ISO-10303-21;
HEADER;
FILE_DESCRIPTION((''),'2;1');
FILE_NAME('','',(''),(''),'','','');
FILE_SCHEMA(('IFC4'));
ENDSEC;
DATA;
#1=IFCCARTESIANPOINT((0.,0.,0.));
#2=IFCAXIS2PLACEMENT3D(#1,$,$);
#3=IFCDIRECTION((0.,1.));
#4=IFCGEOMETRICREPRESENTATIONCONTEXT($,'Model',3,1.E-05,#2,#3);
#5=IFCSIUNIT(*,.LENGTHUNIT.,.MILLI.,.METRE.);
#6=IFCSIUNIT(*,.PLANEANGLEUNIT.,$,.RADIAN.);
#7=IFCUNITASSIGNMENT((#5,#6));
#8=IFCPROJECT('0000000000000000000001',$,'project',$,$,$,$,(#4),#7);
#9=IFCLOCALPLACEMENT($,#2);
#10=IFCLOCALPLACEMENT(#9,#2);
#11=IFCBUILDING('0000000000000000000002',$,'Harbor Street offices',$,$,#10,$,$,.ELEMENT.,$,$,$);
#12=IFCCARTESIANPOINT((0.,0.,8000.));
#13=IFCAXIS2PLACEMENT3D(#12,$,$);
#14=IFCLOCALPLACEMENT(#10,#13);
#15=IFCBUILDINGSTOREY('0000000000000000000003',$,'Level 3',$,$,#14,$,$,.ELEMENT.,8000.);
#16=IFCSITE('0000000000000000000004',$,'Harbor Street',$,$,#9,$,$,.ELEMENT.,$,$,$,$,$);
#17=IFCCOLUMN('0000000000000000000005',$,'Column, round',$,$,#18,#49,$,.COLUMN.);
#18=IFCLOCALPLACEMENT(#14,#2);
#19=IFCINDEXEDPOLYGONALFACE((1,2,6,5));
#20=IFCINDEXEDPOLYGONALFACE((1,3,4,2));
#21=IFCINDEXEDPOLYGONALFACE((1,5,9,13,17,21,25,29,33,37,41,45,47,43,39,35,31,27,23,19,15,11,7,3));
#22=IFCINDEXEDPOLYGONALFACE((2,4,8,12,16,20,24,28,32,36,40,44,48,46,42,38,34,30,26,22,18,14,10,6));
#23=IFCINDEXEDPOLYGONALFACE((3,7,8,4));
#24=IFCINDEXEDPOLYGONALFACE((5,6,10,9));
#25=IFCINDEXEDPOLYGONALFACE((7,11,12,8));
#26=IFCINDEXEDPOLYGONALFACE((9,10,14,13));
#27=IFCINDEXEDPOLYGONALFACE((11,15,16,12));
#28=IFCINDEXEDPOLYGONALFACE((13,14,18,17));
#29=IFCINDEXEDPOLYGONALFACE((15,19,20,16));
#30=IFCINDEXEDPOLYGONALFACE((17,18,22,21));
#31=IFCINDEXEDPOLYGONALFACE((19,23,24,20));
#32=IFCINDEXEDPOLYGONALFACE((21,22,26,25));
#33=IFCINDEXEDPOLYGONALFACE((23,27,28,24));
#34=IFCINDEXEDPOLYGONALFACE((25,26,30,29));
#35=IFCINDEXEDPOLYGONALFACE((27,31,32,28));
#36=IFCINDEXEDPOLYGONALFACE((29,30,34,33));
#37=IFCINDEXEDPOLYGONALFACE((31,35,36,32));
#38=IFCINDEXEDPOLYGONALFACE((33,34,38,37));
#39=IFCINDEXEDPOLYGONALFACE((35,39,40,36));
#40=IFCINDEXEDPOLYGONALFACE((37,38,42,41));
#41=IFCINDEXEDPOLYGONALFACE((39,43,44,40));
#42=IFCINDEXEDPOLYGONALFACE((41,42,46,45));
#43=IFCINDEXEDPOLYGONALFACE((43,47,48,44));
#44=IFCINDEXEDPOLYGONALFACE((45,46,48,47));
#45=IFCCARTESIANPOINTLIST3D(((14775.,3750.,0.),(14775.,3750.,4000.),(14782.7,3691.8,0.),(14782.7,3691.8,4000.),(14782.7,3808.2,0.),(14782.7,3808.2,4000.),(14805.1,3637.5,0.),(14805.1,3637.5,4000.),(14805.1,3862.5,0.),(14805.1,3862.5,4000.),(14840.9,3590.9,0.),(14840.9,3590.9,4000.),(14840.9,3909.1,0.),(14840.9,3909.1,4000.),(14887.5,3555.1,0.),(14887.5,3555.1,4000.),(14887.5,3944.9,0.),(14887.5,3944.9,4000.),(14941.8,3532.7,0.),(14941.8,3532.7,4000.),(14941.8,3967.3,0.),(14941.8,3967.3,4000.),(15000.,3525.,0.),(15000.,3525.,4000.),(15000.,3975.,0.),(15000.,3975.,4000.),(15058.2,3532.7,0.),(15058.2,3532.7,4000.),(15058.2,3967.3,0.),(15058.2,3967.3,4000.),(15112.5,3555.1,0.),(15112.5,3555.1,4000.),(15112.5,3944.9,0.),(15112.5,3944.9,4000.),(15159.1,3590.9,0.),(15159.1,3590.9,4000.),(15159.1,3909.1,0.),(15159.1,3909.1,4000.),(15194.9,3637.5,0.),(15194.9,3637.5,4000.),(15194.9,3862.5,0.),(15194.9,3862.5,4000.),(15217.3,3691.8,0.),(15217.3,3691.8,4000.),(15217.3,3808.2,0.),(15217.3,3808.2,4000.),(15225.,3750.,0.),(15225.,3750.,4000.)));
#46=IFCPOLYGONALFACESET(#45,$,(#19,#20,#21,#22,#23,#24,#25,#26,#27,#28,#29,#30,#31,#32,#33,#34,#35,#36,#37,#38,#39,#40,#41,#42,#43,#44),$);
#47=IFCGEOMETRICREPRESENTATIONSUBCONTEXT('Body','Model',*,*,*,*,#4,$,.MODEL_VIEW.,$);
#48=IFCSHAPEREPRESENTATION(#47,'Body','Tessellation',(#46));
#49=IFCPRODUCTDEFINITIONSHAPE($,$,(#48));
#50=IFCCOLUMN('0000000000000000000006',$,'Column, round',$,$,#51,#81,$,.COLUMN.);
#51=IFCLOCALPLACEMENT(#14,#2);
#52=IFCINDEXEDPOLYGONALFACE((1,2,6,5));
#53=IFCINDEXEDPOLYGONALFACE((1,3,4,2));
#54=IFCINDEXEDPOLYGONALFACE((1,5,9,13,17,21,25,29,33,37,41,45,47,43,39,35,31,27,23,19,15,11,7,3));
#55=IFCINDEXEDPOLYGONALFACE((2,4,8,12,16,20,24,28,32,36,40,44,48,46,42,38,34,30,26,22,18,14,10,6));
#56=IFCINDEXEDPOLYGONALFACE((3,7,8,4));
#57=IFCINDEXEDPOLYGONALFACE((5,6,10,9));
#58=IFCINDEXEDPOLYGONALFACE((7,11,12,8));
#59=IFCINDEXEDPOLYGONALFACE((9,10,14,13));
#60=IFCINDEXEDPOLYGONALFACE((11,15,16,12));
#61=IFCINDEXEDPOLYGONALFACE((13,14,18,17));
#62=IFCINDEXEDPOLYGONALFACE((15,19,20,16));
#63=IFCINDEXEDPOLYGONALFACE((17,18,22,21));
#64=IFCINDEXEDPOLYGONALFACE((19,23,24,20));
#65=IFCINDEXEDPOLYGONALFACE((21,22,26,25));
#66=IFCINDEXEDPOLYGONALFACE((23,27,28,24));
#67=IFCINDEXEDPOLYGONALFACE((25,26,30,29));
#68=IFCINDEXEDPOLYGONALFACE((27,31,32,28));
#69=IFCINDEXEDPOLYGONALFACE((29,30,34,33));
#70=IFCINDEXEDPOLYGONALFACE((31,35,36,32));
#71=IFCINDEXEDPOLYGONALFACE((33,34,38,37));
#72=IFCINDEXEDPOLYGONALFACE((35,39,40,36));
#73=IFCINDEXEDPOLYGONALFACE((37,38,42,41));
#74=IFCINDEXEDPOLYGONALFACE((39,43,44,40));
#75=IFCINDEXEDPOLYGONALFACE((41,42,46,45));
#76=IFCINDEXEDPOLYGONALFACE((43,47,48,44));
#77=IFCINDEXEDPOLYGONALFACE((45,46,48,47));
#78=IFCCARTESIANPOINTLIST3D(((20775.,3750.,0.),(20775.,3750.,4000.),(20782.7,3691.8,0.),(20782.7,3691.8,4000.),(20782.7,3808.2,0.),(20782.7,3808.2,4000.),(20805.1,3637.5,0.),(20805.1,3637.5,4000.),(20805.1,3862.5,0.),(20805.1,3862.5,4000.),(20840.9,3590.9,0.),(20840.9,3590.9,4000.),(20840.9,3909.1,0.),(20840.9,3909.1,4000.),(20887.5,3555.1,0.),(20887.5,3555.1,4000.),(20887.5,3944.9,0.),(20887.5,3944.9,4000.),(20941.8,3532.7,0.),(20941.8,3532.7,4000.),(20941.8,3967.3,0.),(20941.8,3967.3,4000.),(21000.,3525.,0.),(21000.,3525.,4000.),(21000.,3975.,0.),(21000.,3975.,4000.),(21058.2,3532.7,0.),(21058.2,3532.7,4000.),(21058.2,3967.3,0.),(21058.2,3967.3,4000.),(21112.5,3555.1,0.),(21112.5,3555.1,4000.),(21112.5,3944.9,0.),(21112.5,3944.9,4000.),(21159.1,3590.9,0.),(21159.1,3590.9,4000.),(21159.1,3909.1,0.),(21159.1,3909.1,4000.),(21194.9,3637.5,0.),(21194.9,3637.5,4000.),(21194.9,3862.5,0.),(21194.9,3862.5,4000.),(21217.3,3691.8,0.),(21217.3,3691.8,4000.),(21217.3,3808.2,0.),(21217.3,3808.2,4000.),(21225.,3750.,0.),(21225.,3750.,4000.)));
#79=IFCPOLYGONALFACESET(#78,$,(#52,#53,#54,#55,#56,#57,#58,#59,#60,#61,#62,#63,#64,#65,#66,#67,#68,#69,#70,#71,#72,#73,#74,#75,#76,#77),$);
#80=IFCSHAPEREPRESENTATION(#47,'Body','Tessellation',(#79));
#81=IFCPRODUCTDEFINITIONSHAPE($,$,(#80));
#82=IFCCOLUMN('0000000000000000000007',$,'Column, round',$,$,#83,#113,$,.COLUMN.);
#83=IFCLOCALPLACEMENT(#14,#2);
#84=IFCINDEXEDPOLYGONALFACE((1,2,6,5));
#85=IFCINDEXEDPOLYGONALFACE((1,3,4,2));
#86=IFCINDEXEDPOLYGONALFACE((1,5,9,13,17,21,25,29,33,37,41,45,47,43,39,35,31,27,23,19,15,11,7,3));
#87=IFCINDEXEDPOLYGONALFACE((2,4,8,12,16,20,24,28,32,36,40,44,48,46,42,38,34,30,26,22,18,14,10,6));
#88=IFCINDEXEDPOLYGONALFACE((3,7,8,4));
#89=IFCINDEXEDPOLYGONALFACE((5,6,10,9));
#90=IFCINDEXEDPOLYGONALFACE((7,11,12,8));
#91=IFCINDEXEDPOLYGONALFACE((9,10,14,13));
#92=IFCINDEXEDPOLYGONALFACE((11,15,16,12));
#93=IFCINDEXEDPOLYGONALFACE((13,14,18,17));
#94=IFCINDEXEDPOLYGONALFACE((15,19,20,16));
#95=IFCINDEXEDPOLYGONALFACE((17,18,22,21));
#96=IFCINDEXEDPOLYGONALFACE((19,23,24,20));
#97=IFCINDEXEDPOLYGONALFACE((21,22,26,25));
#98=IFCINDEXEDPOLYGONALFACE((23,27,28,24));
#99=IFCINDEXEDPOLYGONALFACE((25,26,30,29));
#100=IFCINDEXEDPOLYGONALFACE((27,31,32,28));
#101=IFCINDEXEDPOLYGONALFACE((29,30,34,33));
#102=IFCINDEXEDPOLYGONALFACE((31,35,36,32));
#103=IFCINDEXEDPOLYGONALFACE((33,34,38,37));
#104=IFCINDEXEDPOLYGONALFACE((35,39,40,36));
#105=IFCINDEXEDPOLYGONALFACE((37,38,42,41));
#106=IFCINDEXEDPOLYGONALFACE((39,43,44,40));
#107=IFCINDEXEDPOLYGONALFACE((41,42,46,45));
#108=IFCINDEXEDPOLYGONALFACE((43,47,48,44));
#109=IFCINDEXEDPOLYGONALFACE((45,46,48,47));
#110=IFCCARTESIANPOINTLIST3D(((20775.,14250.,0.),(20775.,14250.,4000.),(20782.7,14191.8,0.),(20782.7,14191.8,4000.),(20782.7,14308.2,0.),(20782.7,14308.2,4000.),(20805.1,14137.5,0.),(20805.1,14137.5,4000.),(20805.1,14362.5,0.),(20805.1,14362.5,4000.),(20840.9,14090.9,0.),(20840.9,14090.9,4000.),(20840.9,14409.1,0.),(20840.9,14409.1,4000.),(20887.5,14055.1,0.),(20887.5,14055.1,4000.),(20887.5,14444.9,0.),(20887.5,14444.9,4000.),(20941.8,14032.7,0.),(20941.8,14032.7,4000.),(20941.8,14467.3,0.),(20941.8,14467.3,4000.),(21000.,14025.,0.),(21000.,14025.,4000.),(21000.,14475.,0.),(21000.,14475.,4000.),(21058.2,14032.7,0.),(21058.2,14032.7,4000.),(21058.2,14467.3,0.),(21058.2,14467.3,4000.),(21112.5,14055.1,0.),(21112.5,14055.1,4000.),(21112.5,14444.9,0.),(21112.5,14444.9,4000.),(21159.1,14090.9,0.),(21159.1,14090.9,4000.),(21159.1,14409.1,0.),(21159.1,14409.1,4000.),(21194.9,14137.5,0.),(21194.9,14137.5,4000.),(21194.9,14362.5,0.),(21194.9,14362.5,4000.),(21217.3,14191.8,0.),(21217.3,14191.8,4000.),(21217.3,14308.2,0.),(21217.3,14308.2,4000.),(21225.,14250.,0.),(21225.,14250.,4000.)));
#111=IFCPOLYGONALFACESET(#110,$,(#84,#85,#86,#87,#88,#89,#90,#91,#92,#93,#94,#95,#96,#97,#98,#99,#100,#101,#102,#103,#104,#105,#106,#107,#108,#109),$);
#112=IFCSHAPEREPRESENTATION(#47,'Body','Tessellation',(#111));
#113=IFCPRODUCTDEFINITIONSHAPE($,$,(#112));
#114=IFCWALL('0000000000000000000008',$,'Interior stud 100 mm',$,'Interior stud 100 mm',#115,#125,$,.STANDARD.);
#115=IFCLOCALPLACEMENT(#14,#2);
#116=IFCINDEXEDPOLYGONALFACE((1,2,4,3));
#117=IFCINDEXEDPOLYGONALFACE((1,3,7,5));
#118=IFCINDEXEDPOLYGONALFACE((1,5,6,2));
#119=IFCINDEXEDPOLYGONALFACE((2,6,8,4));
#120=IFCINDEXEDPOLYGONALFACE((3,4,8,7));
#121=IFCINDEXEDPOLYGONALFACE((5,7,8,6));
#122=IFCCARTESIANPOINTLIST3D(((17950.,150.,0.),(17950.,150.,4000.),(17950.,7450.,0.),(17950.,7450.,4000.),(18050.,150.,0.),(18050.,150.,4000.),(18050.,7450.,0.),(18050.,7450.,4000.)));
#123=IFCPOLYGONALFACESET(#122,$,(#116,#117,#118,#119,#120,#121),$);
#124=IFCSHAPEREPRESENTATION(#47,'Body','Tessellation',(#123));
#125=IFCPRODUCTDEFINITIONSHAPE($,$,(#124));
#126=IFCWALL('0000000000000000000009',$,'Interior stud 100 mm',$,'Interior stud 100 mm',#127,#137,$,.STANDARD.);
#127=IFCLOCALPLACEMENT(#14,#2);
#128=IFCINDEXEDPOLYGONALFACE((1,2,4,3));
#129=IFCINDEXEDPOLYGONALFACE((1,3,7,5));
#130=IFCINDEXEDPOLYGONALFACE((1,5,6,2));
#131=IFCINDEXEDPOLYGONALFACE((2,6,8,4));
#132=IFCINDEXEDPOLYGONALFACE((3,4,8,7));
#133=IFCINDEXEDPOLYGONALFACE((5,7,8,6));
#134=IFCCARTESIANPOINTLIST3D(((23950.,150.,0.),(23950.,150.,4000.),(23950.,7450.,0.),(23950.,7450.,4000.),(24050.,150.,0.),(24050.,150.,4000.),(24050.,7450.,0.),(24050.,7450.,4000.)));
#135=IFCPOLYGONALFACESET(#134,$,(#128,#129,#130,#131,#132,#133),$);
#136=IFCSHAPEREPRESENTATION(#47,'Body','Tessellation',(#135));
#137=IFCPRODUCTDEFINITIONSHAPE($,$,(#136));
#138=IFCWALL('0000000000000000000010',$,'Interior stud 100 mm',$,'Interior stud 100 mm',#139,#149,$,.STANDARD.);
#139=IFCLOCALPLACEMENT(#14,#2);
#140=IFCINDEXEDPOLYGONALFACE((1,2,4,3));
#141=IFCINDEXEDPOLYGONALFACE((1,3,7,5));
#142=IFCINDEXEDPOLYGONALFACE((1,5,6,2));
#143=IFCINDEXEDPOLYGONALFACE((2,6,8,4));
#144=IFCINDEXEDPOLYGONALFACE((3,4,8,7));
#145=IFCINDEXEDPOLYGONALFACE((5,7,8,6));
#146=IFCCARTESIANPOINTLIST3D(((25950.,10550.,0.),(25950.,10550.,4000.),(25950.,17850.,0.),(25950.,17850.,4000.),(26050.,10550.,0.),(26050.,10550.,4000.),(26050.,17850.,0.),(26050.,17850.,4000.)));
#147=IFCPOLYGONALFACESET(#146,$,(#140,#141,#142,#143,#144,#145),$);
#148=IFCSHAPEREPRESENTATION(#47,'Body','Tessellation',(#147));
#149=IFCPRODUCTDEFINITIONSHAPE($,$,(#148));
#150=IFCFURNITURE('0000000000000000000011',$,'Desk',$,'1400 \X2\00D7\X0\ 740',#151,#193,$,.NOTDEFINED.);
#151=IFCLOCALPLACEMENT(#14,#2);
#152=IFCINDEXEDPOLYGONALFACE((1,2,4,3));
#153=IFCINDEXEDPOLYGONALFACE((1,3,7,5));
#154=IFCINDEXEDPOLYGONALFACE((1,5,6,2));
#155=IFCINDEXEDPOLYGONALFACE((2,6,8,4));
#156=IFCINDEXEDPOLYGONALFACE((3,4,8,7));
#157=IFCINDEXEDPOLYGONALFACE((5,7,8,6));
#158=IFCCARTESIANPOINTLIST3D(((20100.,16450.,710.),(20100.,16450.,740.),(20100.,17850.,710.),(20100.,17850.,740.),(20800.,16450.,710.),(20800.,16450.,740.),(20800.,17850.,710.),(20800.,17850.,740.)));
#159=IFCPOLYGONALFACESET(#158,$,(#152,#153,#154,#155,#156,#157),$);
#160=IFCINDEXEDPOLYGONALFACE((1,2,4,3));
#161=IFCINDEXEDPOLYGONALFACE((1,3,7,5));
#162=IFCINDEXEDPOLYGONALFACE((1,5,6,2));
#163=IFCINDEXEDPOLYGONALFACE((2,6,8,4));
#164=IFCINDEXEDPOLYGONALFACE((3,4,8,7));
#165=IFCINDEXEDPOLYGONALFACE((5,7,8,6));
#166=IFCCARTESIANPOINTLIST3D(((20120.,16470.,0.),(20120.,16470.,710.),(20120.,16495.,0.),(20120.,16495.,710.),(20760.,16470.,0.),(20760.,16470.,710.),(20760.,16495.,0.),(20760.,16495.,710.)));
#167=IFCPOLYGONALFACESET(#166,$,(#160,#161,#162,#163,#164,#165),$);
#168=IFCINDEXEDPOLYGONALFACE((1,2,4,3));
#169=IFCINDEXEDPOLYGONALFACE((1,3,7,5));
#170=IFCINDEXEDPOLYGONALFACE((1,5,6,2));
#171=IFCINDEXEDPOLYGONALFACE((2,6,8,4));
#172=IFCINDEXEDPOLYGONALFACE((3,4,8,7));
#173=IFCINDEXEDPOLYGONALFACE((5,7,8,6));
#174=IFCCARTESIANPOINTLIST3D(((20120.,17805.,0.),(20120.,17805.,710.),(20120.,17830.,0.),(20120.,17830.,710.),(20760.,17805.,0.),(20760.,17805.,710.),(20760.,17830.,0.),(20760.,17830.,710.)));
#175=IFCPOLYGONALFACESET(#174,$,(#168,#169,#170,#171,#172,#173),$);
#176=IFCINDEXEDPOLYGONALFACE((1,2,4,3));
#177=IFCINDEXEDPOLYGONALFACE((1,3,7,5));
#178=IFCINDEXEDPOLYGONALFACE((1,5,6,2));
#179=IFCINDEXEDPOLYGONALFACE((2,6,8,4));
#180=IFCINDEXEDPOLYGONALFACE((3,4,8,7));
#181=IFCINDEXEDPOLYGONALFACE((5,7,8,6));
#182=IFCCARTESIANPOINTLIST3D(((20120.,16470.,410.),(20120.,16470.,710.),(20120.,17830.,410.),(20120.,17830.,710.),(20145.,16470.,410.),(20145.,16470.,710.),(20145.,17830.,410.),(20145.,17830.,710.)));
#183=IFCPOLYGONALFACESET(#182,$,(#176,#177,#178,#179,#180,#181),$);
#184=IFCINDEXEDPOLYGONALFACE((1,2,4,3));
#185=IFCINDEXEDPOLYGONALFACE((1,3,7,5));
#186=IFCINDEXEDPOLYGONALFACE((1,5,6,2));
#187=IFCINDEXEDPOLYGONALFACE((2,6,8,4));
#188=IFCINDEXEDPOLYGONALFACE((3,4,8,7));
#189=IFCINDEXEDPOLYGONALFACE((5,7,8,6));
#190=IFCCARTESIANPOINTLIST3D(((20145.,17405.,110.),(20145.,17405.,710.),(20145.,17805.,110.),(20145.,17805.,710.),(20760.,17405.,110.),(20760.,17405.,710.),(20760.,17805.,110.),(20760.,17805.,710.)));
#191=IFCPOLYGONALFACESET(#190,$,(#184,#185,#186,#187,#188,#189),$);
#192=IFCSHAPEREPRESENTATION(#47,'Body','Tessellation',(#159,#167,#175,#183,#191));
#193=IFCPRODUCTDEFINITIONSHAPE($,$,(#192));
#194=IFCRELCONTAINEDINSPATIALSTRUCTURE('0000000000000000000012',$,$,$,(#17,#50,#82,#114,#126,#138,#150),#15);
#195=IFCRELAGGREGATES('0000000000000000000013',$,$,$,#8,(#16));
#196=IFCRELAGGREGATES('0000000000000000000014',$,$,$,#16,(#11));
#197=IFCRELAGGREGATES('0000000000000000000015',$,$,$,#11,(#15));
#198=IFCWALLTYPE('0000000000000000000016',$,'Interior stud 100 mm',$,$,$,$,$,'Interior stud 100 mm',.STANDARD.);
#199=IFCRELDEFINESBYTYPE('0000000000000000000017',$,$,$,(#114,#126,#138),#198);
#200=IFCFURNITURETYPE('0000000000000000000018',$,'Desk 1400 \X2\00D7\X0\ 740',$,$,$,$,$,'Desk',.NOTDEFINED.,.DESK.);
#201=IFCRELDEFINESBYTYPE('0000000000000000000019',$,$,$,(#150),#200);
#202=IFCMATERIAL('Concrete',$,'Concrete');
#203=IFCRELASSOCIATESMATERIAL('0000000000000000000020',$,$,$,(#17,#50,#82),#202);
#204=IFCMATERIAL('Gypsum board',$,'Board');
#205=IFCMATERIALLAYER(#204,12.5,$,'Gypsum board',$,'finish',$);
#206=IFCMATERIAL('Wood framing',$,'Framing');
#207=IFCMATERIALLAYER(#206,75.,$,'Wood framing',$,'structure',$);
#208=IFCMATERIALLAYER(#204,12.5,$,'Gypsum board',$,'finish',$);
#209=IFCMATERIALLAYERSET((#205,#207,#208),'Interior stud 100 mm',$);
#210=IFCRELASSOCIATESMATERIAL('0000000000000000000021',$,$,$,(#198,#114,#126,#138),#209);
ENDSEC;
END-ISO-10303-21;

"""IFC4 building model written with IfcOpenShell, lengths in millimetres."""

from ifc_helpers import new_model, si_unit, direction, frame, origin, origin_2d, place, context, subcontext, project, spatial, polyline, circle, outline, extrude, source, transform, mapped, material, layer, layer_set, layer_usage, type_object, type_shapes, element, save


model = new_model("IFC4")

# Units and contexts
model_context = context("Model", 3, precision=1e-05, world=origin(), true_north=direction((0.0, 1.0)))
body_context = subcontext(model_context, "Body", "Model", "MODEL_VIEW")
ifc_project = project(units=[si_unit("LENGTHUNIT", "METRE", prefix="MILLI"), si_unit("PLANEANGLEUNIT", "RADIAN")], contexts=[model_context])

# Site, building, storey
site_placement = place(None, origin())
site = spatial("IfcSite", under=ifc_project, at=site_placement, Name="Harbor Street", CompositionType="ELEMENT")
building_placement = place(site_placement, origin())
building = spatial("IfcBuilding", under=site, at=building_placement, Name="Harbor Street offices", CompositionType="ELEMENT")
storey_placement = place(building_placement, frame((0.0, 0.0, 8000.0)))
storey = spatial("IfcBuildingStorey", under=building, at=storey_placement, Name="Level 3", CompositionType="ELEMENT", Elevation=8000.0)

# Columns
ifc_material_1 = material(Name="Concrete", Category="Concrete")
for number, where, z_axis, x_axis, name in (
    (1, (15000.0, 3750.0, 0.0), (0.0, 0.0, 1.0), (1.0, 0.0, 0.0), "Column, round"),
    (2, (21000.0, 3750.0, 0.0), (0.0, 0.0, 1.0), (1.0, 0.0, 0.0), "Column, round"),
    (3, (21000.0, 14250.0, 0.0), (0.0, 0.0, 1.0), (1.0, 0.0, 0.0), "Column, round"),
):
    element("IfcColumn", number, at=place(storey_placement, frame(where, z_axis=z_axis, x_axis=x_axis)), inside=storey, material=ifc_material_1, Name=name, PredefinedType="COLUMN", context=body_context, shape_type="SweptSolid", body=[
        extrude(circle(Radius=225.0, at=origin_2d()), origin(), (0.0, 0.0, 1.0), 4000.0),
    ])

# Walls
ifc_material_2 = material(Name="Gypsum board", Category="Board")
ifc_layer_1 = layer(ifc_material_2, 12.5, Name="Gypsum board", Category="finish")
ifc_material_3 = material(Name="Wood framing", Category="Framing")
ifc_layer_2 = layer(ifc_material_3, 75.0, Name="Wood framing", Category="structure")
ifc_layer_3 = layer(ifc_material_2, 12.5, Name="Gypsum board", Category="finish")
ifc_layer_set_1 = layer_set([ifc_layer_1, ifc_layer_2, ifc_layer_3], Name="Interior stud 100 mm")
ifc_layer_usage_1 = layer_usage(ifc_layer_set_1, "AXIS2", "NEGATIVE", 50.0)
wall_type_1 = type_object("IfcWallType", Name="Interior stud 100 mm", ElementType="Interior stud 100 mm", PredefinedType="STANDARD", material=ifc_layer_set_1)
wall_1_placement = place(storey_placement, frame((18000.0, 0.0, 0.0), z_axis=(0.0, 0.0, 1.0), x_axis=(0.0, 1.0, 0.0)))
element("IfcWall", 4, at=wall_1_placement, inside=storey, type_object=wall_type_1, material=ifc_layer_usage_1, Name="Interior stud 100 mm", ObjectType="Interior stud 100 mm", PredefinedType="STANDARD", context=body_context, shape_type="SweptSolid", body=[
    extrude(outline(polyline([(150.0, -50.0), (7450.0, -50.0), (7450.0, 50.0), (150.0, 50.0), (150.0, -50.0)])), origin(), (0.0, 0.0, 1.0), 4000.0),
])
ifc_layer_usage_2 = layer_usage(ifc_layer_set_1, "AXIS2", "NEGATIVE", 50.0)
wall_2_placement = place(storey_placement, frame((24000.0, 0.0, 0.0), z_axis=(0.0, 0.0, 1.0), x_axis=(0.0, 1.0, 0.0)))
element("IfcWall", 5, at=wall_2_placement, inside=storey, type_object=wall_type_1, material=ifc_layer_usage_2, Name="Interior stud 100 mm", ObjectType="Interior stud 100 mm", PredefinedType="STANDARD", context=body_context, shape_type="SweptSolid", body=[
    extrude(outline(polyline([(150.0, -50.0), (7450.0, -50.0), (7450.0, 50.0), (150.0, 50.0), (150.0, -50.0)])), origin(), (0.0, 0.0, 1.0), 4000.0),
])
ifc_layer_usage_3 = layer_usage(ifc_layer_set_1, "AXIS2", "NEGATIVE", 50.0)
wall_3_placement = place(storey_placement, frame((26000.0, 10500.0, 0.0), z_axis=(0.0, 0.0, 1.0), x_axis=(0.0, 1.0, 0.0)))
element("IfcWall", 6, at=wall_3_placement, inside=storey, type_object=wall_type_1, material=ifc_layer_usage_3, Name="Interior stud 100 mm", ObjectType="Interior stud 100 mm", PredefinedType="STANDARD", context=body_context, shape_type="SweptSolid", body=[
    extrude(outline(polyline([(50.0, -50.0), (7350.0, -50.0), (7350.0, 50.0), (50.0, 50.0), (50.0, -50.0)])), origin(), (0.0, 0.0, 1.0), 4000.0),
])

# Furniture
furniture_type_1 = type_object("IfcFurnitureType", Name="Desk 1400 × 740", ElementType="Desk", AssemblyPlace="NOTDEFINED", PredefinedType="DESK")
shared_shape_1 = source(origin(), body_context, "Body", "SweptSolid", [
    extrude(outline(polyline([(-700.0, 0.0), (700.0, 0.0), (700.0, 700.0), (-700.0, 700.0), (-700.0, 0.0)])), frame((0.0, 0.0, 710.0)), (0.0, 0.0, 1.0), 30.0),
    extrude(outline(polyline([(-680.0, 40.0), (-655.0, 40.0), (-655.0, 680.0), (-680.0, 680.0), (-680.0, 40.0)])), origin(), (0.0, 0.0, 1.0), 710.0),
    extrude(outline(polyline([(655.0, 40.0), (680.0, 40.0), (680.0, 680.0), (655.0, 680.0), (655.0, 40.0)])), origin(), (0.0, 0.0, 1.0), 710.0),
    extrude(outline(polyline([(-680.0, 655.0), (680.0, 655.0), (680.0, 680.0), (-680.0, 680.0), (-680.0, 655.0)])), frame((0.0, 0.0, 410.0)), (0.0, 0.0, 1.0), 300.0),
    extrude(outline(polyline([(255.0, 40.0), (655.0, 40.0), (655.0, 655.0), (255.0, 655.0), (255.0, 40.0)])), frame((0.0, 0.0, 110.0)), (0.0, 0.0, 1.0), 600.0),
])
type_shapes(furniture_type_1, [shared_shape_1])
for number, where, z_axis, x_axis, name in (
    (7, (20800.0, 17150.0, 0.0), (0.0, 0.0, 1.0), (0.0, 1.0, 0.0), "Desk"),
):
    element("IfcFurniture", number, at=place(storey_placement, frame(where, z_axis=z_axis, x_axis=x_axis)), inside=storey, type_object=furniture_type_1, Name=name, ObjectType="1400 × 740", PredefinedType="NOTDEFINED", context=body_context, shape_type="MappedRepresentation", body=[
        mapped(shared_shape_1, transform((0.0, 0.0, 0.0))),
    ])

save(model, "model.ifc")
